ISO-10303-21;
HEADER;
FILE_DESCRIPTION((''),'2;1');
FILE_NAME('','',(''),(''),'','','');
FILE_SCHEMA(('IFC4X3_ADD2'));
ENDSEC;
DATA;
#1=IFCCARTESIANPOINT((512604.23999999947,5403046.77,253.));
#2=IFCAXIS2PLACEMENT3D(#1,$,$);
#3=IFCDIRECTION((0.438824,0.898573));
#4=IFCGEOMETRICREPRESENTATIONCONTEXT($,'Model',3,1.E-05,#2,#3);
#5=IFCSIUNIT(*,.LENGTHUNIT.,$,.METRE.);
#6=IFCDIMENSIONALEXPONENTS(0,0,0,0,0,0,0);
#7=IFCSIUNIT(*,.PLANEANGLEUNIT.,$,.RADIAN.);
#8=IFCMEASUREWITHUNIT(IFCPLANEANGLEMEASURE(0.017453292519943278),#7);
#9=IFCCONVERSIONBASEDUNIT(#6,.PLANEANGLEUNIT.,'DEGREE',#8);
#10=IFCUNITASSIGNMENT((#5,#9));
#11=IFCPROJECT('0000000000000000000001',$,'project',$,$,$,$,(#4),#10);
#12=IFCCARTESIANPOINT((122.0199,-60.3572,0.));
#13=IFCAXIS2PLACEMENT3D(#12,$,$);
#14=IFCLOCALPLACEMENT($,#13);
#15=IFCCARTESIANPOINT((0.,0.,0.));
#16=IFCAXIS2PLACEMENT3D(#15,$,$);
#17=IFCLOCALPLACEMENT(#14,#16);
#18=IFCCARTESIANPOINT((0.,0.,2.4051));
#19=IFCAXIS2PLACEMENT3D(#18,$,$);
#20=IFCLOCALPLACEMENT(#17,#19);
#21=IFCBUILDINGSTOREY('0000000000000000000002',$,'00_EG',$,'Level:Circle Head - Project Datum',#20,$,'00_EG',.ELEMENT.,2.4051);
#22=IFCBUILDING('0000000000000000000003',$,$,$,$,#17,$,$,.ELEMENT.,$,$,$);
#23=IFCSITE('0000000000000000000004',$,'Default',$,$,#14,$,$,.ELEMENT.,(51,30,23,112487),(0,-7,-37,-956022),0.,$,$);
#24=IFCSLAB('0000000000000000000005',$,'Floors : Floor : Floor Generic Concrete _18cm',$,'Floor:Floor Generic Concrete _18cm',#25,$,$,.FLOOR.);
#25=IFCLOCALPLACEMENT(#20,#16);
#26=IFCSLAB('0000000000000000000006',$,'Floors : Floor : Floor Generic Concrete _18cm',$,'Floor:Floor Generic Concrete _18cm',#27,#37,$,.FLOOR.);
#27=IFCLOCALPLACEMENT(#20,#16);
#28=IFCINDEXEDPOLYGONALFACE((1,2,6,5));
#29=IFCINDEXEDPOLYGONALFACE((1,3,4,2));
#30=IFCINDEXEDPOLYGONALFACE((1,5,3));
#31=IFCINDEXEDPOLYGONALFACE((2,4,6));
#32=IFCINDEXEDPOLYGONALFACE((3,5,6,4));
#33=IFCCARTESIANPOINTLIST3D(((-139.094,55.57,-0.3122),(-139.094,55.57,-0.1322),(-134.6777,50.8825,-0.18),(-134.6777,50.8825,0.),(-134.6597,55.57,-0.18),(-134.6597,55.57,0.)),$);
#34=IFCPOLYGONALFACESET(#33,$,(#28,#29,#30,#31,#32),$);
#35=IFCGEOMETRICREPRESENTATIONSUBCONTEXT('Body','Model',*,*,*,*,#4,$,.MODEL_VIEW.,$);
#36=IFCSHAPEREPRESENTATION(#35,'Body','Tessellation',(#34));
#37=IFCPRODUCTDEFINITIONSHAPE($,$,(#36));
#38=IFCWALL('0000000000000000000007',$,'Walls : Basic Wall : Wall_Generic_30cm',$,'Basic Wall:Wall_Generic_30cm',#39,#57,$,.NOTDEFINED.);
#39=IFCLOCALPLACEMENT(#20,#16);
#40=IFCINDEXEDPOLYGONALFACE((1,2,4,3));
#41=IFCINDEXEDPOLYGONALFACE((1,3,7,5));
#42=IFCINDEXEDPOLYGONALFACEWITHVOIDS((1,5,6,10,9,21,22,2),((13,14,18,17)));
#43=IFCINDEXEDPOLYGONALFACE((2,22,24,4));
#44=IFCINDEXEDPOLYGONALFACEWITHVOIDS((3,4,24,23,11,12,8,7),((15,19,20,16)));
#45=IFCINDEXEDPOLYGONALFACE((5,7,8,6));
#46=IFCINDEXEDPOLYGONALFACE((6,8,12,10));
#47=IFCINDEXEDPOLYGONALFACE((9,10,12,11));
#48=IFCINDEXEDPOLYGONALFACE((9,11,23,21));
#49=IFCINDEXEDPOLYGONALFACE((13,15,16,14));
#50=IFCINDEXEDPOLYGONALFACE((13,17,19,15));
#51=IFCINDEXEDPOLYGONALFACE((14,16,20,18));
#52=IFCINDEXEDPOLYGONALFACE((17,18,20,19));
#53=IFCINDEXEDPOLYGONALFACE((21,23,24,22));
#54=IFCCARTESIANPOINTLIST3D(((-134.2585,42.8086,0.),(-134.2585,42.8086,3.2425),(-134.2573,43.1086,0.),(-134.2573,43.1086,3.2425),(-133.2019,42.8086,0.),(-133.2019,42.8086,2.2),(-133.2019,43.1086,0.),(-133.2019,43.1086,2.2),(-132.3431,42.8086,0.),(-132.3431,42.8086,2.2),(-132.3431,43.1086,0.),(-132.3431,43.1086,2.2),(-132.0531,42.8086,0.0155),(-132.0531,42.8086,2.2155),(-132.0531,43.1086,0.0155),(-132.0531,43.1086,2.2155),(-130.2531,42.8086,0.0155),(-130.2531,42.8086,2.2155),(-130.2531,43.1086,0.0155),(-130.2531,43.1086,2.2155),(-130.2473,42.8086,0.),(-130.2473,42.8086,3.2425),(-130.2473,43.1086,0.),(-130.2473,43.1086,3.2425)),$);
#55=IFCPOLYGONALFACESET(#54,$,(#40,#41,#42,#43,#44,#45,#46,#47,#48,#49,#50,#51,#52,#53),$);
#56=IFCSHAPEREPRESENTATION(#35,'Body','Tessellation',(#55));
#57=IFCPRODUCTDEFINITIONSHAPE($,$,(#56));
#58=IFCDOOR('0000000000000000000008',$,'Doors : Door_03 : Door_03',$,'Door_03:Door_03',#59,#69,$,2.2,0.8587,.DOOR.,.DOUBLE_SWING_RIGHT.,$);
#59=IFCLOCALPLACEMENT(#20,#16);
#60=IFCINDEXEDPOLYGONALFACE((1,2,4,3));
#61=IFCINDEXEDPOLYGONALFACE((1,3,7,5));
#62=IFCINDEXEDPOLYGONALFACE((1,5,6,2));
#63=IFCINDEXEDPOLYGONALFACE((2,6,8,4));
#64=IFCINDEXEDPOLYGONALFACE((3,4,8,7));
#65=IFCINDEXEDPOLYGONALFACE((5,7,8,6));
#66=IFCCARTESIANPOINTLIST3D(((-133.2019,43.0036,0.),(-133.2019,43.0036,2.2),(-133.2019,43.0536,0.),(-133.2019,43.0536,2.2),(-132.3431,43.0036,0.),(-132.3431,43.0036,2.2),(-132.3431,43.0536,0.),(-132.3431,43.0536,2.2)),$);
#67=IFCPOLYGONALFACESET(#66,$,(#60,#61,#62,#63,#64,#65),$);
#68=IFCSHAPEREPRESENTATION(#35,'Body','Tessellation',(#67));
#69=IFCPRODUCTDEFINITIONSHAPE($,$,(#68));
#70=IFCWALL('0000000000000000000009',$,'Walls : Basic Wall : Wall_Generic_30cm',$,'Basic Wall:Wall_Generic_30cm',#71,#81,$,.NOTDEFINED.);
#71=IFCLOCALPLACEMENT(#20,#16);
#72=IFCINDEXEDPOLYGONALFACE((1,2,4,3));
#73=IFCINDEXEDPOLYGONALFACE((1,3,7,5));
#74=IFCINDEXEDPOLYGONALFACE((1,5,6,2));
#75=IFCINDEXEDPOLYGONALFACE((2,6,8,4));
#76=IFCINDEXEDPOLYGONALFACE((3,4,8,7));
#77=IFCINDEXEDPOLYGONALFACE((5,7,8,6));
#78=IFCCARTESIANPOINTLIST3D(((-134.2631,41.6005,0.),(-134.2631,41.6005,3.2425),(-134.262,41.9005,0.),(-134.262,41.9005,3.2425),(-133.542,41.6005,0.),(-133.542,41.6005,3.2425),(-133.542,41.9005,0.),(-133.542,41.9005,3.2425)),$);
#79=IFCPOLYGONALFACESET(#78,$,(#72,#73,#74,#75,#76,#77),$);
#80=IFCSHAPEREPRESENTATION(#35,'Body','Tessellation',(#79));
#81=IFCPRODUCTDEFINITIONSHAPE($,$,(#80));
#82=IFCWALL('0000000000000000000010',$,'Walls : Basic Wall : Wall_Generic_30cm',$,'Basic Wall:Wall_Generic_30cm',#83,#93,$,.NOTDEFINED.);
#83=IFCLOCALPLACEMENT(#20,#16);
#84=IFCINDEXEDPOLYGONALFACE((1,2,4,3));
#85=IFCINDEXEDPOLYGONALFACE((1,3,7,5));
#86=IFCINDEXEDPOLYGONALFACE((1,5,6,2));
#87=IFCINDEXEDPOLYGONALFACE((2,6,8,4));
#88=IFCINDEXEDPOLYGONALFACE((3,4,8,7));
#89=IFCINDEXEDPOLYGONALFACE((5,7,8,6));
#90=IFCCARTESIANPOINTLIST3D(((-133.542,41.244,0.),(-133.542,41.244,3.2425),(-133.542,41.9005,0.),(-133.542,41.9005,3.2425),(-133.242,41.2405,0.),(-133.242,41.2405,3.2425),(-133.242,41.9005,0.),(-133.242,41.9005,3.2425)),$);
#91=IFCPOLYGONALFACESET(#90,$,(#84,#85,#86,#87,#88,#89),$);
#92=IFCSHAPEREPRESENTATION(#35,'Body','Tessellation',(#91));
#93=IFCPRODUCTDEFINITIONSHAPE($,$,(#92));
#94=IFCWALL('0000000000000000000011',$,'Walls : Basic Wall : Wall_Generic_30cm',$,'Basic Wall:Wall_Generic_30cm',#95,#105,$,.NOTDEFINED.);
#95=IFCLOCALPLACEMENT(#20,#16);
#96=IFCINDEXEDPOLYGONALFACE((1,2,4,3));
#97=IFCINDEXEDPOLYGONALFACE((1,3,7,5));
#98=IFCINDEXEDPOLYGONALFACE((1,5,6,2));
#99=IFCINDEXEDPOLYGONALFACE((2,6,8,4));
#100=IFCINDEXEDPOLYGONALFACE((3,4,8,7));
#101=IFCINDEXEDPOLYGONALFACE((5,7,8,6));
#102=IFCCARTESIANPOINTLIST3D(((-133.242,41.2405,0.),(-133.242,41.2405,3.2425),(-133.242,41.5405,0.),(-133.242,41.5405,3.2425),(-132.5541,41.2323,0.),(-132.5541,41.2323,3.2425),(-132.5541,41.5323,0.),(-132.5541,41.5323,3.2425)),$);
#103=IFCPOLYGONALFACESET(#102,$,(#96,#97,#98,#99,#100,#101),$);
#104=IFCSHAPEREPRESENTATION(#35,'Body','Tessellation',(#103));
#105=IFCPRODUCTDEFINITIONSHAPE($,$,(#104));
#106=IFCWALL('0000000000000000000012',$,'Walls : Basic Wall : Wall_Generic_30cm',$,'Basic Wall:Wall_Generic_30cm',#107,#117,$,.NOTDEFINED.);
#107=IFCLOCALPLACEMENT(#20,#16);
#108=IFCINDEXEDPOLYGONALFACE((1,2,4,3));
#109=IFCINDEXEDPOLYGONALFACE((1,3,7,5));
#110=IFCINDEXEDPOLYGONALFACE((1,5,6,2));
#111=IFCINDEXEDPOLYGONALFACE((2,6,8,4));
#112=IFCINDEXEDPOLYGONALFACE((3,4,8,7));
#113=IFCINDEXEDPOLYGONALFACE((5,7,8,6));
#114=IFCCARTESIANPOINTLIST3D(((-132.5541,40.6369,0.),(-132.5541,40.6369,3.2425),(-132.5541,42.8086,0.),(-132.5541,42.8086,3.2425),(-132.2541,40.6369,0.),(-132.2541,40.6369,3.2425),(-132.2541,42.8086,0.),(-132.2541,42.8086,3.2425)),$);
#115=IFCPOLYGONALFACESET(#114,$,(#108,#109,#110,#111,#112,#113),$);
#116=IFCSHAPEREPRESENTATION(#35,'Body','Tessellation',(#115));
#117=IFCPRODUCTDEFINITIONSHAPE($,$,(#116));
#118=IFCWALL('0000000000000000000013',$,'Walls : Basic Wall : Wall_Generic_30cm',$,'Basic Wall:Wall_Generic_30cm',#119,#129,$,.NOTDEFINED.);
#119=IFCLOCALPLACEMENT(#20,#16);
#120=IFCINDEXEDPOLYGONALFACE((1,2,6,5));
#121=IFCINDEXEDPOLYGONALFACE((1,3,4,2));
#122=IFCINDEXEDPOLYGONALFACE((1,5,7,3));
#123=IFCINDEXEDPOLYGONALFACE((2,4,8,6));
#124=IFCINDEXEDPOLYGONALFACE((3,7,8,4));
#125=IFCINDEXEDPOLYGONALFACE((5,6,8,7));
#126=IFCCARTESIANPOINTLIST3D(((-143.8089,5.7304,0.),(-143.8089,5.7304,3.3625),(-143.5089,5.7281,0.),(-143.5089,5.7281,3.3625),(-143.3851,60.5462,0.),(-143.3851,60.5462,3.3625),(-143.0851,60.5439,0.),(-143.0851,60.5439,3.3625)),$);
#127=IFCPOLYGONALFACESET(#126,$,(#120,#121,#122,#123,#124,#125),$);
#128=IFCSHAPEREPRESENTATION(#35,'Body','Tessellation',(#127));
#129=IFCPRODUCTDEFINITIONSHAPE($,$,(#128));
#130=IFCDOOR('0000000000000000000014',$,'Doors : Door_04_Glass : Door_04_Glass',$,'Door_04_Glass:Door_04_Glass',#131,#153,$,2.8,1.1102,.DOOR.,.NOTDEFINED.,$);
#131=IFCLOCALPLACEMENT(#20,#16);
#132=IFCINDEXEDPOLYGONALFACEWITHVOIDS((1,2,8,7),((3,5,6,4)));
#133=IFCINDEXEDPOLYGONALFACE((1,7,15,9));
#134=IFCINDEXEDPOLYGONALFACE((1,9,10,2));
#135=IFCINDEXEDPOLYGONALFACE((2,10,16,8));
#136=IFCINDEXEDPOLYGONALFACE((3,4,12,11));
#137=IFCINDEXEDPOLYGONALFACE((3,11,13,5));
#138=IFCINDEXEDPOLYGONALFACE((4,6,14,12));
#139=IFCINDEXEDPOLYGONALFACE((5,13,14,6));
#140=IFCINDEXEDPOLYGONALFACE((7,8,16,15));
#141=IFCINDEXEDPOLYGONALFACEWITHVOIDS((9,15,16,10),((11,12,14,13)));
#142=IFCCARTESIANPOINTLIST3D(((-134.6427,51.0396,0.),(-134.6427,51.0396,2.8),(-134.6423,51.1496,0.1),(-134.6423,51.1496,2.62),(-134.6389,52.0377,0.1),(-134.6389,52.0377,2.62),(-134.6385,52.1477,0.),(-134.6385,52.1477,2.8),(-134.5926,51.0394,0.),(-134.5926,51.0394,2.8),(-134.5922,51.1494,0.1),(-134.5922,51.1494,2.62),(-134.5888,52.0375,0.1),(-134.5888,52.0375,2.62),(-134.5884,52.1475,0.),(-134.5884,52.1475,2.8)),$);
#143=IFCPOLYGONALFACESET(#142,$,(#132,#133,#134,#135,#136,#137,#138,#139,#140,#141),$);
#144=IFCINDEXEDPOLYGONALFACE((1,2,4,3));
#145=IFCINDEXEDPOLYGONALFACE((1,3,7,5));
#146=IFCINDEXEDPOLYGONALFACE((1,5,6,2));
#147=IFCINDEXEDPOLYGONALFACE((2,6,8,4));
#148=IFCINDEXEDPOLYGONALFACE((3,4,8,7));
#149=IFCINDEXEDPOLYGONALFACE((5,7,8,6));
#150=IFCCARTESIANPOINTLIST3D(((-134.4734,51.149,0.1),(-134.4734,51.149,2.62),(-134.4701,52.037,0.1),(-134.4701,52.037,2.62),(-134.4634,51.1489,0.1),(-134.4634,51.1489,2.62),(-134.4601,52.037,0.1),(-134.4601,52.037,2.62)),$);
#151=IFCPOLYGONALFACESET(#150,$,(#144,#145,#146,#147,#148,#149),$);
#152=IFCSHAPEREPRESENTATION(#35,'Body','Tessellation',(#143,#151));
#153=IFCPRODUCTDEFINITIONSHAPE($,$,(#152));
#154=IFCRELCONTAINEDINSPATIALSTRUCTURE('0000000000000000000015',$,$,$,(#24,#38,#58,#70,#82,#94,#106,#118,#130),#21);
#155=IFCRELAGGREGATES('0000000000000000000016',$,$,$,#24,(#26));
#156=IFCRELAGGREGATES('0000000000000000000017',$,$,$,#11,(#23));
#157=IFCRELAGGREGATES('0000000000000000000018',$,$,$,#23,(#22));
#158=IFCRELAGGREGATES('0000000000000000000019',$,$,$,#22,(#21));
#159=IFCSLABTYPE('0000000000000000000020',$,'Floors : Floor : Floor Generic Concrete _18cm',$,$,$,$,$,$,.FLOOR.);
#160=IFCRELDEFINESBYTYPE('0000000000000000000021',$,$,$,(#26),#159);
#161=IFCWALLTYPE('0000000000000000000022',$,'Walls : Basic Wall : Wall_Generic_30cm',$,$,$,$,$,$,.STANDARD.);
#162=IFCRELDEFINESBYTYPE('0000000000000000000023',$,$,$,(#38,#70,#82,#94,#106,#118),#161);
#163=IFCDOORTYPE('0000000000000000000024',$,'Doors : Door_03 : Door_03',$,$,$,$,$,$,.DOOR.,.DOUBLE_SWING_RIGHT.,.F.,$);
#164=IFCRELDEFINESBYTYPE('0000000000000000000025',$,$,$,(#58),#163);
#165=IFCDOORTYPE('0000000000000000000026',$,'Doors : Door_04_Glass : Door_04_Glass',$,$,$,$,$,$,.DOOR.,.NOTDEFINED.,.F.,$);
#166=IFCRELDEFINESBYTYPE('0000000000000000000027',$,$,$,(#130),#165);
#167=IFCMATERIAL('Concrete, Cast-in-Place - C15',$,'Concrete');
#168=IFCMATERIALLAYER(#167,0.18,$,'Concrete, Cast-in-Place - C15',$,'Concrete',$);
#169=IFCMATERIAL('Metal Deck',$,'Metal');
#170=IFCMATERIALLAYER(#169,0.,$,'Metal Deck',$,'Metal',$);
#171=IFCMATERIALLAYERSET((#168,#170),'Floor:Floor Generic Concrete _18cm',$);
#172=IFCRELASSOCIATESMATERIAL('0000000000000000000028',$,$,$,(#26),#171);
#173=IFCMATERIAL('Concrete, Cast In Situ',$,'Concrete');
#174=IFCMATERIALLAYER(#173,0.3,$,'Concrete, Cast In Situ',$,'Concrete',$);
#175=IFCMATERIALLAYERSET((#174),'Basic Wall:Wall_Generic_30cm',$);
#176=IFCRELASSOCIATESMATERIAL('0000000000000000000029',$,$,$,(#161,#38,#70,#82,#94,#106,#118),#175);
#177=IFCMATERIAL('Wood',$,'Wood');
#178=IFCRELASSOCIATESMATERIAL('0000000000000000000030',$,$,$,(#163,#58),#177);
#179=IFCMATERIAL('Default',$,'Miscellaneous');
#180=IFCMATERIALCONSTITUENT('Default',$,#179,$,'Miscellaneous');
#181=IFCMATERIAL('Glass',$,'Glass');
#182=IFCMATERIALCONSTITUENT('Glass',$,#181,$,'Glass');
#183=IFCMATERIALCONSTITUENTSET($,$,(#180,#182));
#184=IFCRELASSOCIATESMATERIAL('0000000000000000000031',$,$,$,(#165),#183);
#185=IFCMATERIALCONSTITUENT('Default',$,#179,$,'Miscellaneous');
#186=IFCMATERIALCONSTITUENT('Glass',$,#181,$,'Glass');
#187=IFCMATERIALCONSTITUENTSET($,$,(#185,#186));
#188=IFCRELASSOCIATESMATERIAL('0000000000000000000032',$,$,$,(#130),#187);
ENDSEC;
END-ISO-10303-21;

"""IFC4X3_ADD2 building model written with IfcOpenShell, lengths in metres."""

from ifc_helpers import new_model, entity, si_unit, converted_unit, direction, frame, frame_2d, origin, origin_2d_with_axis, place, context, subcontext, project, spatial, polyline, rectangle, outline, extrude, clip, halfspace, bounded_halfspace, source, transform, mapped, material, layer, layer_set, constituent, constituent_set, type_object, type_shapes, element, fill, aggregate, save


model = new_model("IFC4X3_ADD2")

# Units and contexts
model_context = context("Model", 3, precision=1e-05, world=frame((512604.23999999947, 5403046.77, 253.0)), true_north=direction((0.438824, 0.898573)))
body_context = subcontext(model_context, "Body", "Model", "MODEL_VIEW")
ifc_project = project(units=[si_unit("LENGTHUNIT", "METRE"), converted_unit("PLANEANGLEUNIT", "DEGREE", entity("IfcPlaneAngleMeasure", 0.017453292519943278), si_unit("PLANEANGLEUNIT", "RADIAN"), dimensions=[0, 0, 0, 0, 0, 0, 0])], contexts=[model_context])

# Site, building, storey
site_placement = place(None, frame((122.0199, -60.3572, 0.0)))
site = spatial("IfcSite", under=ifc_project, at=site_placement, Name="Default", CompositionType="ELEMENT", RefLatitude=(51, 30, 23, 112487), RefLongitude=(0, -7, -37, -956022), RefElevation=0.0)
building_placement = place(site_placement, origin())
building = spatial("IfcBuilding", under=site, at=building_placement, CompositionType="ELEMENT")
storey_placement = place(building_placement, frame((0.0, 0.0, 2.4051)))
storey = spatial("IfcBuildingStorey", under=building, at=storey_placement, Name="00_EG", ObjectType="Level:Circle Head - Project Datum", LongName="00_EG", CompositionType="ELEMENT", Elevation=2.4051)

# Slabs
slab_1_placement = place(storey_placement, frame((-143.1593, 50.8825, -0.4352)))
slab_1 = element("IfcSlab", 1, at=slab_1_placement, inside=storey, Name="Floors : Floor : Floor Generic Concrete _18cm", ObjectType="Floor:Floor Generic Concrete _18cm", PredefinedType="FLOOR")
ifc_material_1 = material(Name="Concrete, Cast-in-Place - C15", Category="Concrete")
ifc_layer_1 = layer(ifc_material_1, 0.18, Name="Concrete, Cast-in-Place - C15", Category="Concrete")
ifc_material_2 = material(Name="Metal Deck", Category="Metal")
ifc_layer_2 = layer(ifc_material_2, 0.0, Name="Metal Deck", Category="Metal")
ifc_layer_set_1 = layer_set([ifc_layer_1, ifc_layer_2], Name="Floor:Floor Generic Concrete _18cm")
slab_type = type_object("IfcSlabType", Name="Floors : Floor : Floor Generic Concrete _18cm", PredefinedType="FLOOR")
slab_2_placement = place(slab_1_placement, origin())
slab_2 = element("IfcSlab", 2, at=slab_2_placement, type_object=slab_type, material=ifc_layer_set_1, Name="Floors : Floor : Floor Generic Concrete _18cm", ObjectType="Floor:Floor Generic Concrete _18cm", PredefinedType="FLOOR", context=body_context, shape_type="SweptSolid", body=[
    extrude(outline(polyline([(2.2181, 2.3438), (-2.2181, 2.3438), (2.2002, -2.3438), (2.2181, 2.3438)])), frame((6.2824, 2.3438, 0.3694), z_axis=(-0.0298, 0.000114, 0.999556), x_axis=(0.999556, 0.000003, 0.0298)), (-0.0298, 0.000114, -0.999556), 0.18),
])
aggregate(slab_1, [slab_2])

# Wall, openings, door
ifc_material_3 = material(Name="Concrete, Cast In Situ", Category="Concrete")
ifc_layer_3 = layer(ifc_material_3, 0.3, Name="Concrete, Cast In Situ", Category="Concrete")
ifc_layer_set_2 = layer_set([ifc_layer_3], Name="Basic Wall:Wall_Generic_30cm")
wall_type = type_object("IfcWallType", Name="Walls : Basic Wall : Wall_Generic_30cm", PredefinedType="STANDARD", material=ifc_layer_set_2)
wall_1_placement = place(storey_placement, frame((-134.2585, 42.9586, 0.0)))
wall_1 = element("IfcWall", 3, at=wall_1_placement, inside=storey, type_object=wall_type, material=ifc_layer_set_2, Name="Walls : Basic Wall : Wall_Generic_30cm", ObjectType="Basic Wall:Wall_Generic_30cm", PredefinedType="NOTDEFINED", context=body_context, shape_type="Clipping", body=[
    clip(extrude(outline(polyline([(0.0, -0.15), (1.7044, -0.15), (2.0044, -0.15), (4.0112, -0.15), (4.0112, 0.15), (0.0011, 0.15), (0.0, -0.15)])), origin(), (0.0, 0.0, 1.0), 3.2425), bounded_halfspace(frame((0.0, -0.15, 3.2425), z_axis=(0.0, 0.0, -1.0), x_axis=(0.0, -1.0, 0.0)), True, frame((0.0, -0.15, 3.2425)), polyline([(0.0, 0.0), (1.7044, 0.0), (2.0044, 0.0), (4.0112, 0.0), (4.0112, 0.3), (0.0011, 0.3), (0.0, 0.0)]))),
])
opening_1_placement = place(wall_1_placement, frame((134.2585, -42.9586, 0.0155)))
element("IfcOpeningElement", 4, at=opening_1_placement, cuts=wall_1, PredefinedType="OPENING", context=body_context, shape_type="SweptSolid", body=[
    extrude(rectangle(XDim=2.2, YDim=1.8, at=origin_2d_with_axis()), frame((-131.1531, 41.2846, 1.1), z_axis=(0.0, 1.0, 0.0), x_axis=(0.0, 0.0, 1.0)), (0.0, 0.0, 1.0), 3.048),
])
opening_2_placement = place(wall_1_placement, frame((134.2585, -42.9586, 0.0)))
opening_2 = element("IfcOpeningElement", 5, at=opening_2_placement, cuts=wall_1, PredefinedType="OPENING", context=body_context, shape_type="SweptSolid", body=[
    extrude(rectangle(XDim=2.2, YDim=0.8587, at=frame_2d((0.0, 0.0), x_axis=(0.0, 1.0))), frame((-132.7725, 42.8086, 1.1), z_axis=(0.0, 1.0, 0.0), x_axis=(1.0, 0.0, 0.0)), (0.0, 0.0, 1.0), 0.3),
])
ifc_material_4 = material(Name="Wood", Category="Wood")
door_type_1 = type_object("IfcDoorType", Name="Doors : Door_03 : Door_03", OperationType="DOUBLE_SWING_RIGHT", ParameterTakesPrecedence=False, PredefinedType="DOOR", material=ifc_material_4)
shared_shape_1 = source(origin(), body_context, "Body", "SweptSolid", [
    extrude(rectangle(XDim=0.05, YDim=0.8587, at=frame_2d((0.0, 0.0), x_axis=(1.0, 0.0))), frame((0.4294, 0.08, 0.0), z_axis=(0.0, 0.0, 1.0), x_axis=(0.0, 1.0, 0.0)), (0.0, 0.0, 1.0), 2.2),
])
type_shapes(door_type_1, [shared_shape_1])
door_1_placement = place(opening_2_placement, frame((-132.3431, 43.1086, 0.0), z_axis=(0.0, 0.0, 1.0), x_axis=(-1.0, 0.0, 0.0)))
door_1 = element("IfcDoor", 6, at=door_1_placement, inside=storey, type_object=door_type_1, material=ifc_material_4, Name="Doors : Door_03 : Door_03", ObjectType="Door_03:Door_03", OperationType="DOUBLE_SWING_RIGHT", OverallHeight=2.2, OverallWidth=0.8587, PredefinedType="DOOR", context=body_context, shape_type="MappedRepresentation", body=[
    mapped(shared_shape_1, transform((0.0, 0.0, 0.0), scale=1.0)),
])
fill(opening_2, door_1)

# Walls
wall_2_placement = place(storey_placement, frame((-134.2631, 41.7505, 0.0)))
element("IfcWall", 7, at=wall_2_placement, inside=storey, type_object=wall_type, material=ifc_layer_set_2, Name="Walls : Basic Wall : Wall_Generic_30cm", ObjectType="Basic Wall:Wall_Generic_30cm", PredefinedType="NOTDEFINED", context=body_context, shape_type="Clipping", body=[
    clip(extrude(outline(polyline([(0.7211, -0.15), (0.7211, 0.15), (0.0011, 0.15), (0.0, -0.15), (0.0325, -0.15), (0.5322, -0.15), (0.7211, -0.15)])), origin(), (0.0, 0.0, 1.0), 3.2425), bounded_halfspace(frame((0.0, -0.15, 3.2425), z_axis=(0.0, 0.0, -1.0), x_axis=(0.0, -1.0, 0.0)), True, frame((0.0, -0.15, 3.2425)), polyline([(0.0, 0.0), (0.5322, 0.0), (0.7211, 0.0), (0.7211, 0.3), (0.0011, 0.3), (0.0, 0.0)]))),
])
wall_3_placement = place(storey_placement, frame((-133.392, 41.9005, 0.0), z_axis=(0.0, 0.0, 1.0), x_axis=(0.0, -1.0, 0.0)))
element("IfcWall", 8, at=wall_3_placement, inside=storey, type_object=wall_type, material=ifc_layer_set_2, Name="Walls : Basic Wall : Wall_Generic_30cm", ObjectType="Basic Wall:Wall_Generic_30cm", PredefinedType="NOTDEFINED", context=body_context, shape_type="Clipping", body=[
    clip(extrude(outline(polyline([(0.6565, -0.15), (0.66, 0.15), (0.36, 0.15), (0.0, 0.15), (0.0, -0.15), (0.3, -0.15), (0.3585, -0.15), (0.6565, -0.15)])), origin(), (0.0, 0.0, 1.0), 3.2425), bounded_halfspace(frame((0.0, -0.15, 3.2425), z_axis=(0.0, 0.0, -1.0), x_axis=(1.0, 0.0, 0.0)), True, frame((0.0, -0.15, 3.2425)), polyline([(0.0, 0.0), (0.3, 0.0), (0.3585, 0.0), (0.6565, 0.0), (0.66, 0.3), (0.36, 0.3), (0.0, 0.3), (0.0, 0.0)]))),
])
wall_4_placement = place(storey_placement, frame((-133.2437, 41.3905, 0.0), z_axis=(0.0, 0.0, 1.0), x_axis=(0.99993, -0.011838, 0.0)))
element("IfcWall", 9, at=wall_4_placement, inside=storey, type_object=wall_type, material=ifc_layer_set_2, Name="Walls : Basic Wall : Wall_Generic_30cm", ObjectType="Basic Wall:Wall_Generic_30cm", PredefinedType="NOTDEFINED", context=body_context, shape_type="Clipping", body=[
    clip(extrude(outline(polyline([(0.6914, -0.15), (0.6879, 0.15), (0.0, 0.15), (0.0036, -0.15), (0.6914, -0.15)])), origin(), (0.0, 0.0, 1.0), 3.2425), bounded_halfspace(frame((0.0036, -0.15, 3.2425), z_axis=(0.0, 0.0, -1.0), x_axis=(0.011838, -0.99993, 0.0)), True, frame((0.0036, -0.15, 3.2425)), polyline([(0.0, 0.0), (0.6879, 0.0), (0.6843, 0.3), (-0.0036, 0.3), (0.0, 0.0)]))),
])
wall_5_placement = place(storey_placement, frame((-132.4041, 40.6369, 0.0), z_axis=(0.0, 0.0, 1.0), x_axis=(0.0, 1.0, 0.0)))
element("IfcWall", 10, at=wall_5_placement, inside=storey, type_object=wall_type, material=ifc_layer_set_2, Name="Walls : Basic Wall : Wall_Generic_30cm", ObjectType="Basic Wall:Wall_Generic_30cm", PredefinedType="NOTDEFINED", context=body_context, shape_type="Clipping", body=[
    clip(extrude(rectangle(XDim=2.1717, YDim=0.3, at=frame_2d((1.0858, 0.0), x_axis=(-1.0, 0.0))), origin(), (0.0, 0.0, 1.0), 3.2425), bounded_halfspace(frame((0.0, -0.15, 3.2425), z_axis=(0.0, 0.0, -1.0), x_axis=(-1.0, 0.0, 0.0)), True, frame((0.0, -0.15, 3.2425)), polyline([(0.0, 0.0), (2.1717, 0.0), (2.1717, 0.3), (0.8955, 0.3), (0.5954, 0.3), (0.0, 0.3), (0.0, 0.0)]))),
])
wall_6_placement = place(storey_placement, frame((-143.2351, 60.5451, 0.0), z_axis=(0.0, 0.0, 1.0), x_axis=(-0.007732, -0.99997, 0.0)))
element("IfcWall", 11, at=wall_6_placement, inside=storey, type_object=wall_type, material=ifc_layer_set_2, Name="Walls : Basic Wall : Wall_Generic_30cm", ObjectType="Basic Wall:Wall_Generic_30cm", PredefinedType="NOTDEFINED", context=body_context, shape_type="Clipping", body=[
    clip(extrude(rectangle(XDim=54.8174, YDim=0.3, at=frame_2d((27.4087, 0.0), x_axis=(-1.0, 0.0))), origin(), (0.0, 0.0, 1.0), 3.3625), halfspace(frame((0.0, 0.0, -2.4051)), True)),
])

# Door
ifc_material_5 = material(Name="Default", Category="Miscellaneous")
ifc_constituent_1 = constituent(ifc_material_5, Name="Default", Category="Miscellaneous")
ifc_material_6 = material(Name="Glass", Category="Glass")
ifc_constituent_2 = constituent(ifc_material_6, Name="Glass", Category="Glass")
ifc_constituent_set_1 = constituent_set(constituents=[ifc_constituent_1, ifc_constituent_2])
ifc_constituent_3 = constituent(ifc_material_5, Name="Default", Category="Miscellaneous")
ifc_constituent_4 = constituent(ifc_material_6, Name="Glass", Category="Glass")
ifc_constituent_set_2 = constituent_set(constituents=[ifc_constituent_3, ifc_constituent_4])
door_type_2 = type_object("IfcDoorType", Name="Doors : Door_04_Glass : Door_04_Glass", OperationType="NOTDEFINED", ParameterTakesPrecedence=False, PredefinedType="DOOR", material=ifc_constituent_set_2)
shared_shape_2 = source(origin(), body_context, "Body", "SweptSolid", [
    extrude(outline(polyline([(-1.4, -0.554), (1.4, -0.554), (1.4, 0.554), (-1.4, 0.554), (-1.4, -0.554)]), holes=[polyline([(1.3, 0.444), (1.3, -0.444), (-1.22, -0.444), (-1.22, 0.444), (1.3, 0.444)])]), frame((0.554, 0.0343, 1.4), z_axis=(0.0, 1.0, 0.0), x_axis=(0.0, 0.0, -1.0)), (0.0, 0.0, 1.0), 0.0501),
    extrude(rectangle(XDim=0.8881, YDim=0.01, at=frame_2d((0.0, 0.0), x_axis=(1.0, 0.0))), frame((0.554, 0.2082, 0.1)), (0.0, 0.0, 1.0), 2.52),
])
type_shapes(door_type_2, [shared_shape_2])
door_2_placement = place(storey_placement, frame((-134.6728, 52.1478, 0.0), z_axis=(0.0, 0.0, 1.0), x_axis=(-0.003818, -0.999993, 0.0)))
element("IfcDoor", 12, at=door_2_placement, inside=storey, type_object=door_type_2, material=ifc_constituent_set_1, Name="Doors : Door_04_Glass : Door_04_Glass", ObjectType="Door_04_Glass:Door_04_Glass", OperationType="NOTDEFINED", OverallHeight=2.8, OverallWidth=1.1102, PredefinedType="DOOR", context=body_context, shape_type="MappedRepresentation", body=[
    mapped(shared_shape_2, transform((0.0, 0.0, 0.0), scale=1.0)),
])

save(model, "model.ifc")
